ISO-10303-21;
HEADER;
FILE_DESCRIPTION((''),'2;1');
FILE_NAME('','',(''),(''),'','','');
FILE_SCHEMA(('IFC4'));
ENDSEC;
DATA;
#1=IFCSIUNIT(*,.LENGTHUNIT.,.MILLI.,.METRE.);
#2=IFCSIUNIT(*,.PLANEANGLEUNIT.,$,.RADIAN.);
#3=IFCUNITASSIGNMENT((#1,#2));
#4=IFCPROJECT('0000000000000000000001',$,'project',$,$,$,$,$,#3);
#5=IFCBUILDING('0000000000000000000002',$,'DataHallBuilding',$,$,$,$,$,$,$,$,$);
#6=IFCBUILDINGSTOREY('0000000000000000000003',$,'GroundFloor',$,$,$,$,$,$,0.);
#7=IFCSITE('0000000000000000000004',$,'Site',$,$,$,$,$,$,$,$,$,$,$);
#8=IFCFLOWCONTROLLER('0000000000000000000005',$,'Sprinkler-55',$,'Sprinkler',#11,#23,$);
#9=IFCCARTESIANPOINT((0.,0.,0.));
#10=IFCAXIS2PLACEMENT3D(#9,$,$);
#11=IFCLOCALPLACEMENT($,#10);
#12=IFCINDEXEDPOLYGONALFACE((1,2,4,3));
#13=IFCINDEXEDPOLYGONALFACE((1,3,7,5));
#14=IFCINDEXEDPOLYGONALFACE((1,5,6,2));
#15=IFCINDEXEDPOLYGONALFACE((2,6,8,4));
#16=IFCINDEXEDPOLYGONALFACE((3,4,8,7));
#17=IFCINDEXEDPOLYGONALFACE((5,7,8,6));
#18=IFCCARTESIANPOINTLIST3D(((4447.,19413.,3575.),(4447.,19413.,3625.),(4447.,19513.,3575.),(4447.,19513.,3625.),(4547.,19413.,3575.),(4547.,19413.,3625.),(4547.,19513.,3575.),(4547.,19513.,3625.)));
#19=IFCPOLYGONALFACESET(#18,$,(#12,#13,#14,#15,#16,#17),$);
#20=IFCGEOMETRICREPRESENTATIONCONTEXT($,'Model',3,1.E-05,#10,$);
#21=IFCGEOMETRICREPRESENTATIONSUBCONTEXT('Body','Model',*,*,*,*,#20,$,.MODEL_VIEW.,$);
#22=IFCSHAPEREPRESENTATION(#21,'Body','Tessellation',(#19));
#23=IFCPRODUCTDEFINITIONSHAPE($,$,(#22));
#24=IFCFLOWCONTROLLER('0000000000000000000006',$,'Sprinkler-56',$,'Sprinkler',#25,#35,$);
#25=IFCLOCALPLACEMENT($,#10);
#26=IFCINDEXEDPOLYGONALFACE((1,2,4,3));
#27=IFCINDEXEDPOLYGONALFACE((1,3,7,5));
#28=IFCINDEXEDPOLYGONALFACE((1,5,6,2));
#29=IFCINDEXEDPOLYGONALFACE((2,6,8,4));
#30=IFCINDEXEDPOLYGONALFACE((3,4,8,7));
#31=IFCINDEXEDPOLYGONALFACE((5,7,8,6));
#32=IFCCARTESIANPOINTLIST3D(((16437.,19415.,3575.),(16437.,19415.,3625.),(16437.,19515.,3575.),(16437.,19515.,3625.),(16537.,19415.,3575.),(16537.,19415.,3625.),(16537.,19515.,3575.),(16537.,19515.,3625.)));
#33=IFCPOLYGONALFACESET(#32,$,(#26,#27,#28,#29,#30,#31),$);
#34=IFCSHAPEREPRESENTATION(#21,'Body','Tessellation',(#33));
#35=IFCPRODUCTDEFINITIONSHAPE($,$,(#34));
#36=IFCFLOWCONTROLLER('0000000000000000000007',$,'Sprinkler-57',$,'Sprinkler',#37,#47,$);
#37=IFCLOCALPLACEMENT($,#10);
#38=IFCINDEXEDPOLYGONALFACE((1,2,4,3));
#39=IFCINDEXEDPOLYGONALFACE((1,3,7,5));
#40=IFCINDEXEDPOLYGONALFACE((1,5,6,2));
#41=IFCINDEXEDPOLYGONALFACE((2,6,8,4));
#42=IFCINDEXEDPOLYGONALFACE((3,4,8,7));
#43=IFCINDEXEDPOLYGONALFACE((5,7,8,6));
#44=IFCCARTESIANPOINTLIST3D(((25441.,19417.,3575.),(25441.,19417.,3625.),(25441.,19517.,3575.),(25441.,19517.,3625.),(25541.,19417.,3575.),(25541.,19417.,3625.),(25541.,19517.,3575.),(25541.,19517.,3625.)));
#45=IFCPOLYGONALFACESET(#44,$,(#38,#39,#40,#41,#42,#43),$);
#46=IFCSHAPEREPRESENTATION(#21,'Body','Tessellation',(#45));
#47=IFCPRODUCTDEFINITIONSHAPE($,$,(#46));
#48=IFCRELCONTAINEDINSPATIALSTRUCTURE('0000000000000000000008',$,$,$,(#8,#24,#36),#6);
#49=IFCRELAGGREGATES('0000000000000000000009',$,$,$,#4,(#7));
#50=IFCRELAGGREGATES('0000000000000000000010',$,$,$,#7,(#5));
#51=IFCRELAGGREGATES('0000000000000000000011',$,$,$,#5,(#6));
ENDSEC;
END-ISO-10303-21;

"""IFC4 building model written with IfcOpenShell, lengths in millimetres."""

from ifc_helpers import new_model, si_unit, frame, origin, place, context, subcontext, project, spatial, rectangle, extrude, element, save


model = new_model("IFC4")

# Units and contexts
model_context = context("Model", 3, precision=1e-05, world=origin())
body_context = subcontext(model_context, "Body", "Model", "MODEL_VIEW")
ifc_project = project(units=[si_unit("LENGTHUNIT", "METRE", prefix="MILLI"), si_unit("PLANEANGLEUNIT", "RADIAN")])

# Site, building, storey
site = spatial("IfcSite", under=ifc_project, Name="Site")
building = spatial("IfcBuilding", under=site, Name="DataHallBuilding")
storey = spatial("IfcBuildingStorey", under=building, Name="GroundFloor", Elevation=0.0)

# Flow controllers
flow_controller_1_placement = place(None, origin())
element("IfcFlowController", 1, at=flow_controller_1_placement, inside=storey, Name="Sprinkler-55", ObjectType="Sprinkler", context=body_context, shape_type="SweptSolid", body=[
    extrude(rectangle(XDim=100.0, YDim=100.0), frame((4497.0, 19463.0, 3575.0), z_axis=(0.0, 0.0, 1.0), x_axis=(1.0, 0.0, 0.0)), (0.0, 0.0, 1.0), 50.0),
])
flow_controller_2_placement = place(None, origin())
element("IfcFlowController", 2, at=flow_controller_2_placement, inside=storey, Name="Sprinkler-56", ObjectType="Sprinkler", context=body_context, shape_type="SweptSolid", body=[
    extrude(rectangle(XDim=100.0, YDim=100.0), frame((16487.0, 19465.0, 3575.0), z_axis=(0.0, 0.0, 1.0), x_axis=(1.0, 0.0, 0.0)), (0.0, 0.0, 1.0), 50.0),
])
flow_controller_3_placement = place(None, origin())
element("IfcFlowController", 3, at=flow_controller_3_placement, inside=storey, Name="Sprinkler-57", ObjectType="Sprinkler", context=body_context, shape_type="SweptSolid", body=[
    extrude(rectangle(XDim=100.0, YDim=100.0), frame((25491.0, 19467.0, 3575.0), z_axis=(0.0, 0.0, 1.0), x_axis=(1.0, 0.0, 0.0)), (0.0, 0.0, 1.0), 50.0),
])

save(model, "model.ifc")
